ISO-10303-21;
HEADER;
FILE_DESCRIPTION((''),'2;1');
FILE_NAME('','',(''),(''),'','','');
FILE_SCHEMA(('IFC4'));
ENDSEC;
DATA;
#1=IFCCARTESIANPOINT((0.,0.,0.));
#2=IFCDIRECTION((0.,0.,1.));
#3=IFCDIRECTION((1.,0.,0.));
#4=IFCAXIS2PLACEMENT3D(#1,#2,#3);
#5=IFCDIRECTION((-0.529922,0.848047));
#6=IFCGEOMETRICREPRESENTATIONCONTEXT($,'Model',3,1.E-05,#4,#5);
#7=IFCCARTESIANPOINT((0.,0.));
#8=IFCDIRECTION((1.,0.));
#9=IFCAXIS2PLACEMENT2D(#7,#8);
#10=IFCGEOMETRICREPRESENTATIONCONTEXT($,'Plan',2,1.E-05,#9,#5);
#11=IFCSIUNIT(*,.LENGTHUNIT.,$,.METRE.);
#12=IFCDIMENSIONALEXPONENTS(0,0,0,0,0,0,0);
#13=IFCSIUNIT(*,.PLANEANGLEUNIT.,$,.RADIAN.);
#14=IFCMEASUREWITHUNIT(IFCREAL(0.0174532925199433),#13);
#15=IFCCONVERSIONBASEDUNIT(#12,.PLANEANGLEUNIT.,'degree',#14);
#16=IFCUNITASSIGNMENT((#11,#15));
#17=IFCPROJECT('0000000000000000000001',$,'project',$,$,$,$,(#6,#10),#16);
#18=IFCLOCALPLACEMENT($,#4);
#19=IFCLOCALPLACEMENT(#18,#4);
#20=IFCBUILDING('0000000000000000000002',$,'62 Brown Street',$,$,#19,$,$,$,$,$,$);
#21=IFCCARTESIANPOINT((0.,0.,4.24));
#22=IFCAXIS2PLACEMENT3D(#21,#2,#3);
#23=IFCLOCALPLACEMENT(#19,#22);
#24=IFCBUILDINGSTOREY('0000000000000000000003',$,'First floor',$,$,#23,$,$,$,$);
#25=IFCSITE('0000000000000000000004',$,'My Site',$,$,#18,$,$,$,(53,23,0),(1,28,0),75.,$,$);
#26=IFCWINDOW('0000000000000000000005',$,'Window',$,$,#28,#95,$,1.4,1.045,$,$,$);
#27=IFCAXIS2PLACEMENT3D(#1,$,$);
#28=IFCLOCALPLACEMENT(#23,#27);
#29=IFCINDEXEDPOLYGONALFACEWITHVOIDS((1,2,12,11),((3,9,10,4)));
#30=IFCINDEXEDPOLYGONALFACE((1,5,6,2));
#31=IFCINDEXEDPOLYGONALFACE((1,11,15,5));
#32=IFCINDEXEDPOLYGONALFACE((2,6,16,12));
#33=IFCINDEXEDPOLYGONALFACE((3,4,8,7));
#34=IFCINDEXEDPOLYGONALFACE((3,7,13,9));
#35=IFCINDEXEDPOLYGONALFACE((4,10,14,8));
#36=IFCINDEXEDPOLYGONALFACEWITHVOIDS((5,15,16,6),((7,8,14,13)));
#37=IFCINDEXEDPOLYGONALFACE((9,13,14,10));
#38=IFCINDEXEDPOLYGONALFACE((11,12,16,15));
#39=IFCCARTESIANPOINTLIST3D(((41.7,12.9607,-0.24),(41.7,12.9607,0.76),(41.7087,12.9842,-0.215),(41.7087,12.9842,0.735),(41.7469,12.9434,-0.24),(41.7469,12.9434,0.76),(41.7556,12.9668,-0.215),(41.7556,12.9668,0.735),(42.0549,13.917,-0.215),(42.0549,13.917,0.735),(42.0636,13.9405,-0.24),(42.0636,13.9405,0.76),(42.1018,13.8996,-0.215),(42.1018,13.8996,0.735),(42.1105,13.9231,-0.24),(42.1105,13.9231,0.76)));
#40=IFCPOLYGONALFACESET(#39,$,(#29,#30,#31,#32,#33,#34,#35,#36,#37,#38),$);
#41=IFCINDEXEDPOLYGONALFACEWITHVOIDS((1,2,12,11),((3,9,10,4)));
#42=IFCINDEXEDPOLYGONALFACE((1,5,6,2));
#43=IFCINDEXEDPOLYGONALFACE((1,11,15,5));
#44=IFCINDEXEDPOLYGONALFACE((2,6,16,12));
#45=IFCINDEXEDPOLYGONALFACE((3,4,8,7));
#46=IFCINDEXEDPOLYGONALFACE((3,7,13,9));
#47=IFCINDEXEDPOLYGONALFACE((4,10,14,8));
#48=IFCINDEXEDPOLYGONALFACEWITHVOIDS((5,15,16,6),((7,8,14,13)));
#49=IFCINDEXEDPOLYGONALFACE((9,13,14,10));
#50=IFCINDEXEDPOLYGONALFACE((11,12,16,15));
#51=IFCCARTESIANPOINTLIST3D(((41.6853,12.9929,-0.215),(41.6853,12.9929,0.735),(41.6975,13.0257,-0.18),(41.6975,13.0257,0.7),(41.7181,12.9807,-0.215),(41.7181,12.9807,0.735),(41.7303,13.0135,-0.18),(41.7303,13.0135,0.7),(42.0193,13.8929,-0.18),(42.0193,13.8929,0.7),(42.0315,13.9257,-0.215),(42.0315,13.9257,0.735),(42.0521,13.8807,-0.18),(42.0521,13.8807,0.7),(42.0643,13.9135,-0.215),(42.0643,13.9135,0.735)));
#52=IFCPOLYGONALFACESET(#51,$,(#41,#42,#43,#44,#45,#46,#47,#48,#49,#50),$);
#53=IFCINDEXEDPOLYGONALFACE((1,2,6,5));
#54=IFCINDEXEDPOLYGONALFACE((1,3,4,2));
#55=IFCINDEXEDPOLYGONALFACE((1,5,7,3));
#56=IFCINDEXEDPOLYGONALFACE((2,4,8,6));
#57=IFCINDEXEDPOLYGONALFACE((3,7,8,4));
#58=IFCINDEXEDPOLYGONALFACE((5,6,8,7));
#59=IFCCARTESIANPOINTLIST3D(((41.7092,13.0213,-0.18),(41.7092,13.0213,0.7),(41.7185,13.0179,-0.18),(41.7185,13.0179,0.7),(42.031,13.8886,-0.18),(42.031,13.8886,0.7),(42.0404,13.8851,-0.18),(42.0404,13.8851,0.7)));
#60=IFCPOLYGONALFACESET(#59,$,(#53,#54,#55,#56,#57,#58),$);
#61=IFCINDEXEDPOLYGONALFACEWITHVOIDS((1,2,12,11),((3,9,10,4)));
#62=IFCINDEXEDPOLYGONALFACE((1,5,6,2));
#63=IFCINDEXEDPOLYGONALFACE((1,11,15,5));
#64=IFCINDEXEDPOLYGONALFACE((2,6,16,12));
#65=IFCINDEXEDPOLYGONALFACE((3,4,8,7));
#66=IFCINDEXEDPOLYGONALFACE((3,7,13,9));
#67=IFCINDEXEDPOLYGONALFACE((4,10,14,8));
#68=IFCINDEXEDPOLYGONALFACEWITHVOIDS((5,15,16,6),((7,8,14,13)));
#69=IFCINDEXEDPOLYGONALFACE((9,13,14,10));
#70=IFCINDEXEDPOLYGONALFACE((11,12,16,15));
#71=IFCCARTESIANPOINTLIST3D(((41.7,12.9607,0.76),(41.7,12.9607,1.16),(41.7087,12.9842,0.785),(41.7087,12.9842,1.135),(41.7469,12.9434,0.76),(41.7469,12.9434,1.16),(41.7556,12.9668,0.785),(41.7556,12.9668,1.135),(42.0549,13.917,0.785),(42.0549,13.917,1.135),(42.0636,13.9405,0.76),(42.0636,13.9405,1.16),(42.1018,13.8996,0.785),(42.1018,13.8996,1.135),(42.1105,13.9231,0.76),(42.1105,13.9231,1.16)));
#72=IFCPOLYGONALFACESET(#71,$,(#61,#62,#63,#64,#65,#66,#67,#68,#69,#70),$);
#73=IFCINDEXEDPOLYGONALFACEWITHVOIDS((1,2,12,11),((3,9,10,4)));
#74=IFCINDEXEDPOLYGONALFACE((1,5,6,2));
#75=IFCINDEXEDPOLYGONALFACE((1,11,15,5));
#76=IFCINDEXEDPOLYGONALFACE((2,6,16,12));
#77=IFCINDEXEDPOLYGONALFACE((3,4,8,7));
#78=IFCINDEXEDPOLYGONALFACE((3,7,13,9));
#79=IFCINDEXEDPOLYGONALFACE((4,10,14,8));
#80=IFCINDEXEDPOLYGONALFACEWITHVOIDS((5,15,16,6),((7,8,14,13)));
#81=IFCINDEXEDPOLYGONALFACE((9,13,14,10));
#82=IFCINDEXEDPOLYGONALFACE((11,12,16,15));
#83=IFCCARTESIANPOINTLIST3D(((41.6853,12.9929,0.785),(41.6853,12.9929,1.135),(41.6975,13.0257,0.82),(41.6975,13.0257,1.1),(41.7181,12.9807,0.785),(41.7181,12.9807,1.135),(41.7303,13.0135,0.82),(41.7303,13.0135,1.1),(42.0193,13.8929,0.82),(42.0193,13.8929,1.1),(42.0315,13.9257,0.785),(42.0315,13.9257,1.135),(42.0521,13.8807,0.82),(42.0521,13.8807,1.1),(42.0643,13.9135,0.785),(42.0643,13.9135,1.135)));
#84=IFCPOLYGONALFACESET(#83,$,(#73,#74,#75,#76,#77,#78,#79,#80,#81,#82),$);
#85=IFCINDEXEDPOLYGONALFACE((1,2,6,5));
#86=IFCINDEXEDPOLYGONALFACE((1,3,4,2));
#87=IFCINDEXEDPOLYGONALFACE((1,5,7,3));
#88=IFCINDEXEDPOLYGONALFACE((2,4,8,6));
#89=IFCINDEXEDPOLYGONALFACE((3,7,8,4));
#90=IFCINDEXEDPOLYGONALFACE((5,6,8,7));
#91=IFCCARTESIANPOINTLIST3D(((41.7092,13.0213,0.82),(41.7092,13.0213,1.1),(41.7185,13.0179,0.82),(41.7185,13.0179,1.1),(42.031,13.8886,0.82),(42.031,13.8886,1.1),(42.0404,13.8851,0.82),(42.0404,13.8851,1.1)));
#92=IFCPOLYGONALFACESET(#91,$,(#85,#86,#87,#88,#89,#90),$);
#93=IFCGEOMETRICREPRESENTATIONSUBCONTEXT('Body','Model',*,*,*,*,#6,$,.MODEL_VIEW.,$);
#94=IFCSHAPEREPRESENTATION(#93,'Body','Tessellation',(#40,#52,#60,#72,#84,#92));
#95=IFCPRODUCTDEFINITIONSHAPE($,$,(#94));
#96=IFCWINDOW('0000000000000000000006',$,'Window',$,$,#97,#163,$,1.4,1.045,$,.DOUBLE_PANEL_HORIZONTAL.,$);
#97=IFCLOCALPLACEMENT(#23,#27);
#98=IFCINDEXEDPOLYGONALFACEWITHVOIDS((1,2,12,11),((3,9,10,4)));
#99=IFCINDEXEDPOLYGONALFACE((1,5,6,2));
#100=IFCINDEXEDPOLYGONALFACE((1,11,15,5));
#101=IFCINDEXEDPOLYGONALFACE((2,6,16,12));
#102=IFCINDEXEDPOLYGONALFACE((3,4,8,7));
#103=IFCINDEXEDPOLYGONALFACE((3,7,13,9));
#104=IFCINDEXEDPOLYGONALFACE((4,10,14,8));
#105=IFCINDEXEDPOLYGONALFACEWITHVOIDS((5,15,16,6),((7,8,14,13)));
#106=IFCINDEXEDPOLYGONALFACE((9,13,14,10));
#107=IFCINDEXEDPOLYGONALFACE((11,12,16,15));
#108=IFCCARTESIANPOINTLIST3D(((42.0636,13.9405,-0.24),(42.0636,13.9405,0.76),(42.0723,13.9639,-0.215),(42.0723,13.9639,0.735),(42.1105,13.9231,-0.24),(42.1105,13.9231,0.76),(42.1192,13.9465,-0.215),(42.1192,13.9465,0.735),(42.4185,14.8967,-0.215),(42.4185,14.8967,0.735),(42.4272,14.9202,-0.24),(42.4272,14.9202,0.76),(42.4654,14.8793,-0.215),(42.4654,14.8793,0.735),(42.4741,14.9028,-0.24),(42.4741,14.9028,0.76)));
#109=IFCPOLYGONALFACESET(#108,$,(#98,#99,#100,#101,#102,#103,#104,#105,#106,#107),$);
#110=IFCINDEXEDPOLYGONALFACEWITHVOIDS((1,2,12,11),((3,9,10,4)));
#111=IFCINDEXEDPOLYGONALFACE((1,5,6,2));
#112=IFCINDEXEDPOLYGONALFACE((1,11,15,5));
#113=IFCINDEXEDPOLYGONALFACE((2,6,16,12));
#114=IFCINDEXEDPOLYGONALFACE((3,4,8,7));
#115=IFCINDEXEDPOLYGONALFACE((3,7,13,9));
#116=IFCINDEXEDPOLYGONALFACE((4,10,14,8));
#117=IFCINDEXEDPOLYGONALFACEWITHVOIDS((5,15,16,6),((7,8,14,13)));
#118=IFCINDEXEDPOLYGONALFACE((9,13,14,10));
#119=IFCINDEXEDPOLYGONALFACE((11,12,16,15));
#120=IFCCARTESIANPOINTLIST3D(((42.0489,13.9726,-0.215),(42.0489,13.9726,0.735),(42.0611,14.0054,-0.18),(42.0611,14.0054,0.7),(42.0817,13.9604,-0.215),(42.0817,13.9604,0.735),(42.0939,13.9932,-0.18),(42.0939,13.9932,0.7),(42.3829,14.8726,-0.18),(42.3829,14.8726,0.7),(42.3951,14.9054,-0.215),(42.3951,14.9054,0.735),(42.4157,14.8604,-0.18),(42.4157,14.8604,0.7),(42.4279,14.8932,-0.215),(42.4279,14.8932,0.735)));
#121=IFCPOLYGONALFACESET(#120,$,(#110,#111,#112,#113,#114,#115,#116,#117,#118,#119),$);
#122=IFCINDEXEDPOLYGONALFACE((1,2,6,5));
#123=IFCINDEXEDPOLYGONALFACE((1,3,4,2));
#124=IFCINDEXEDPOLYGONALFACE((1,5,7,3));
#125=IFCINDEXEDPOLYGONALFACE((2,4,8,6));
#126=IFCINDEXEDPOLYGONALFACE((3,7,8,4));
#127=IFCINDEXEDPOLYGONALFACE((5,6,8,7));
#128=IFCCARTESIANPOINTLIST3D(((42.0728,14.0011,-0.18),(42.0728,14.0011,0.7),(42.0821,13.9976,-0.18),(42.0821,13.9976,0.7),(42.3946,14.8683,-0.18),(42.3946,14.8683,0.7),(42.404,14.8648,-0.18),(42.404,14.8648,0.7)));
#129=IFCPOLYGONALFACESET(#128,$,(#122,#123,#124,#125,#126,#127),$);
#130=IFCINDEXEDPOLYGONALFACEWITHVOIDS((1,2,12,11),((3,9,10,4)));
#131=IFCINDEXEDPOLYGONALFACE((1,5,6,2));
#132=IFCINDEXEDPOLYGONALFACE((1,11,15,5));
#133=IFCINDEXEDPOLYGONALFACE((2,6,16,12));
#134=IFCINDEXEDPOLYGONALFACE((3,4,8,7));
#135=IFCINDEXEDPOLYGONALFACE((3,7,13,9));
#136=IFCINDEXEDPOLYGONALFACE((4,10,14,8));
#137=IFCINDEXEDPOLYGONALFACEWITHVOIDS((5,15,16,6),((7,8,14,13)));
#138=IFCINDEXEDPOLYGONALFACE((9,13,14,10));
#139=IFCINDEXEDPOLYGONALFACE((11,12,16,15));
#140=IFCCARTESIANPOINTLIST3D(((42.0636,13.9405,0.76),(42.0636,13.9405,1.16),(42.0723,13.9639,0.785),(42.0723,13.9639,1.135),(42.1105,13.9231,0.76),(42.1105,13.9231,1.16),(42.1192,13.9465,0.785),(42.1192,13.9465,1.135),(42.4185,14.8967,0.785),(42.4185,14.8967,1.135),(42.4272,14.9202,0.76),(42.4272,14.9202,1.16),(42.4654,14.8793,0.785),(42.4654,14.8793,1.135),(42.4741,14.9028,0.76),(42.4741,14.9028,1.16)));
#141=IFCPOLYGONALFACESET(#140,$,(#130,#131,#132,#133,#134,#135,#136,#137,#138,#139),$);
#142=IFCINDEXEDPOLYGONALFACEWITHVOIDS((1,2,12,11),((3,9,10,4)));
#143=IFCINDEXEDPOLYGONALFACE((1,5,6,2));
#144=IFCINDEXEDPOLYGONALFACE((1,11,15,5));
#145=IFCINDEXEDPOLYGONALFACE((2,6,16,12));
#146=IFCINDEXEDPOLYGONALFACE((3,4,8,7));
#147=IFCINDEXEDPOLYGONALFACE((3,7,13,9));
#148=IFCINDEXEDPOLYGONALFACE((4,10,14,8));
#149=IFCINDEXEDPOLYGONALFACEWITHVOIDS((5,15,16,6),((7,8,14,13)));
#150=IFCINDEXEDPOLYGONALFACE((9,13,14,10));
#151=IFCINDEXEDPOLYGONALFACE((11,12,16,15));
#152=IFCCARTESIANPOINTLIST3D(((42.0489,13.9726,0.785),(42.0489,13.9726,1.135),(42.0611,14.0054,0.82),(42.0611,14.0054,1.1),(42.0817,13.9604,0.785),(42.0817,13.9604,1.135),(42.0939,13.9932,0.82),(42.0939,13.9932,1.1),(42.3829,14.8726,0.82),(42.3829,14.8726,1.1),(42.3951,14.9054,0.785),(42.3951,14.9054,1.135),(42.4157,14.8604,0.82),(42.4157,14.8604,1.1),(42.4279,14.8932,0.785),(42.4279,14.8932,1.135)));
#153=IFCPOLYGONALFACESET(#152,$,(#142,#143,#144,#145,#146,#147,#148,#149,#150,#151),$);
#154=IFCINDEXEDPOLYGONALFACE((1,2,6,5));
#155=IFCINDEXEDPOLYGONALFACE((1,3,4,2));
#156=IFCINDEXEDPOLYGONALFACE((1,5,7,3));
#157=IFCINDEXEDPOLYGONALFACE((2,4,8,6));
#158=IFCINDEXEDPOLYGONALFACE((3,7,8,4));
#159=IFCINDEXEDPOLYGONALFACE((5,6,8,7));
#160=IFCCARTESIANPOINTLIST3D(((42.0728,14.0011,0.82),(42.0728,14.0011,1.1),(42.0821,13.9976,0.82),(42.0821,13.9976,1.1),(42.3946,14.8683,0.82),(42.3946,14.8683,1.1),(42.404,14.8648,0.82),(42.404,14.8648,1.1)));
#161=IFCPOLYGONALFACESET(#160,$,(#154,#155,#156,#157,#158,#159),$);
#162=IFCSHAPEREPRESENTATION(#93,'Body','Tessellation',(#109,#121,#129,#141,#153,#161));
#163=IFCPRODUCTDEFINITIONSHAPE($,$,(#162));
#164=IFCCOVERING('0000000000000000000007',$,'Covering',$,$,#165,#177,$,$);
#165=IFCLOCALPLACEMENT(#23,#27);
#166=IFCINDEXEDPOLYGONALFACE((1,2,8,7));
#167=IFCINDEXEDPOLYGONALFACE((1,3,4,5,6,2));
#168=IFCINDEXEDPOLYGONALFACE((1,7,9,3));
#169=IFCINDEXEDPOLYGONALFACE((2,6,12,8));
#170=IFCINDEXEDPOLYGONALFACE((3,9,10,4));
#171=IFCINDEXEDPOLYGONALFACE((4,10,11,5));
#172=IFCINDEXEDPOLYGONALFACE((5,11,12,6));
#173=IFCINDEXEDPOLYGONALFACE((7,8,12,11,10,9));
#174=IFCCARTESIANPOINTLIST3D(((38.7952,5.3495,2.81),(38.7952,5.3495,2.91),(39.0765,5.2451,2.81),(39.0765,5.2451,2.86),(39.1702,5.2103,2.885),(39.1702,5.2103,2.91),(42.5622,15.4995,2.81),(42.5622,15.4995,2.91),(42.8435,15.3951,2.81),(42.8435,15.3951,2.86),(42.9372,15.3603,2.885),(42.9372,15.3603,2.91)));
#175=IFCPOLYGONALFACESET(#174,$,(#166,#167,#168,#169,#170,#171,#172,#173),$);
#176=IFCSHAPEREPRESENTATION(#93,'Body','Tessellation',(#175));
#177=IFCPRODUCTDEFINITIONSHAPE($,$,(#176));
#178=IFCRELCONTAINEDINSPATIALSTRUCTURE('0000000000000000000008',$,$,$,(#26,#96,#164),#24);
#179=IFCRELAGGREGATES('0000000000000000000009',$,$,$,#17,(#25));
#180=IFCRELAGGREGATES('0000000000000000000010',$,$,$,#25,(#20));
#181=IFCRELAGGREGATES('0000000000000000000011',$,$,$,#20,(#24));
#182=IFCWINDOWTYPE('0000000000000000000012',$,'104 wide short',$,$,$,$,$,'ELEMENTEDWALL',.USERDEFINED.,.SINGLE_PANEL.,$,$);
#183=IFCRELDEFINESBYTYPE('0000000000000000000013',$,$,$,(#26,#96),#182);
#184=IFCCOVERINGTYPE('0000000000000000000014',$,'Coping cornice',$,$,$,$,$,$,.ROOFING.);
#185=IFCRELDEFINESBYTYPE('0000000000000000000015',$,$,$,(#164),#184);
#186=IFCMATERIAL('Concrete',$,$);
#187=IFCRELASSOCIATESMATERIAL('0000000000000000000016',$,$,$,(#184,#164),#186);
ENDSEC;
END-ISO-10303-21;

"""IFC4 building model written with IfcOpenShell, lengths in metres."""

from ifc_helpers import new_model, entity, si_unit, converted_unit, direction, frame, origin_with_axes, origin_2d_with_axis, place, context, subcontext, project, spatial, line, indexed_curve, outline, extrude, shape, source, transform, mapped, material, material_profile, profile_set, profile_usage, type_object, type_shapes, element, save


model = new_model("IFC4")

# Units and contexts
model_context = context("Model", 3, precision=1e-05, world=origin_with_axes(), true_north=direction((-0.529922, 0.848047)))
plan_context = context("Plan", 2, precision=1e-05, world=origin_2d_with_axis(), true_north=direction((-0.529922, 0.848047)))
body_context_1 = subcontext(model_context, "Body", "Model", "MODEL_VIEW")
body_context_2 = subcontext(plan_context, "Body", "Plan", "PLAN_VIEW")
ifc_project = project(units=[si_unit("LENGTHUNIT", "METRE"), converted_unit("PLANEANGLEUNIT", "degree", entity("IfcReal", 0.0174532925199433), si_unit("PLANEANGLEUNIT", "RADIAN"), dimensions=[0, 0, 0, 0, 0, 0, 0])], contexts=[model_context, plan_context])

# Site, building, storey
site_placement = place(None, origin_with_axes())
site = spatial("IfcSite", under=ifc_project, at=site_placement, Name="My Site", RefLatitude=(53, 23, 0), RefLongitude=(1, 28, 0), RefElevation=75.0)
building_placement = place(site_placement, origin_with_axes())
building = spatial("IfcBuilding", under=site, at=building_placement, Name="62 Brown Street")
storey_placement = place(building_placement, frame((0.0, 0.0, 4.24), z_axis=(0.0, 0.0, 1.0), x_axis=(1.0, 0.0, 0.0)))
storey = spatial("IfcBuildingStorey", under=building, at=storey_placement, Name="First floor")

# Shared definitions
window_type = type_object("IfcWindowType", Name="104 wide short", ElementType="ELEMENTEDWALL", PartitioningType="SINGLE_PANEL", PredefinedType="USERDEFINED")
shared_shape_1 = source(origin_with_axes(), body_context_1, "Body", "SweptSolid", [
    extrude(outline(indexed_curve([(0.0, 0.0), (1.045, 0.0), (1.045, 1.0), (0.0, 1.0)], segments=[line(1, 2, 3, 4, 1)]), holes=[indexed_curve([(0.025, 0.025), (1.02, 0.025), (1.02, 0.975), (0.025, 0.975)], segments=[line(1, 2, 3, 4, 1)])]), frame((0.0, 0.15, 0.0), z_axis=(0.0, -1.0, 0.0), x_axis=(1.0, 0.0, 0.0)), (0.0, 0.0, -1.0), 0.05),
    extrude(outline(indexed_curve([(0.0, 0.0), (0.995, 0.0), (0.995, 0.95), (0.0, 0.95)], segments=[line(1, 2, 3, 4, 1)]), holes=[indexed_curve([(0.035, 0.035), (0.96, 0.035), (0.96, 0.915), (0.035, 0.915)], segments=[line(1, 2, 3, 4, 1)])]), frame((0.025, 0.19, 0.025), z_axis=(0.0, -1.0, 0.0), x_axis=(1.0, 0.0, 0.0)), (0.0, 0.0, -1.0), 0.035),
    extrude(outline(indexed_curve([(0.035, 0.035), (0.96, 0.035), (0.96, 0.915), (0.035, 0.915)], segments=[line(1, 2, 3, 4, 1)])), frame((0.025, 0.2025, 0.025), z_axis=(0.0, -1.0, 0.0), x_axis=(1.0, 0.0, 0.0)), (0.0, 0.0, -1.0), 0.01),
    extrude(outline(indexed_curve([(0.0, 0.0), (1.045, 0.0), (1.045, 0.4), (0.0, 0.4)], segments=[line(1, 2, 3, 4, 1)]), holes=[indexed_curve([(0.025, 0.025), (1.02, 0.025), (1.02, 0.375), (0.025, 0.375)], segments=[line(1, 2, 3, 4, 1)])]), frame((0.0, 0.15, 1.0), z_axis=(0.0, -1.0, 0.0), x_axis=(1.0, 0.0, 0.0)), (0.0, 0.0, -1.0), 0.05),
    extrude(outline(indexed_curve([(0.0, 0.0), (0.995, 0.0), (0.995, 0.35), (0.0, 0.35)], segments=[line(1, 2, 3, 4, 1)]), holes=[indexed_curve([(0.035, 0.035), (0.96, 0.035), (0.96, 0.315), (0.035, 0.315)], segments=[line(1, 2, 3, 4, 1)])]), frame((0.025, 0.19, 1.025), z_axis=(0.0, -1.0, 0.0), x_axis=(1.0, 0.0, 0.0)), (0.0, 0.0, -1.0), 0.035),
    extrude(outline(indexed_curve([(0.035, 0.035), (0.96, 0.035), (0.96, 0.315), (0.035, 0.315)], segments=[line(1, 2, 3, 4, 1)])), frame((0.025, 0.2025, 1.025), z_axis=(0.0, -1.0, 0.0), x_axis=(1.0, 0.0, 0.0)), (0.0, 0.0, -1.0), 0.01),
])
shared_shape_2 = source(origin_with_axes(), body_context_2, "Body", "Curve2D", [
    entity("IfcIndexedPolyCurve", entity("IfcCartesianPointList2D", [[0.025, 0.15], [1.02, 0.15]])),
    entity("IfcIndexedPolyCurve", entity("IfcCartesianPointList2D", [[0.0, 0.2], [0.025, 0.2], [0.025, 0.15], [0.0, 0.15]]), [entity("IfcLineIndex", [1, 2, 3, 4, 1])]),
    entity("IfcIndexedPolyCurve", entity("IfcCartesianPointList2D", [[1.045, 0.2], [1.02, 0.2], [1.02, 0.15], [1.045, 0.15]]), [entity("IfcLineIndex", [1, 2, 3, 4, 1])]),
    entity("IfcIndexedPolyCurve", entity("IfcCartesianPointList2D", [[0.025, 0.19], [0.06, 0.19], [0.06, 0.225], [0.025, 0.225]]), [entity("IfcLineIndex", [1, 2, 3, 4, 1])]),
    entity("IfcIndexedPolyCurve", entity("IfcCartesianPointList2D", [[1.02, 0.19], [0.985, 0.19], [0.985, 0.225], [1.02, 0.225]]), [entity("IfcLineIndex", [1, 2, 3, 4, 1])]),
    entity("IfcIndexedPolyCurve", entity("IfcCartesianPointList2D", [[0.06, 0.19], [0.985, 0.19]])),
    entity("IfcIndexedPolyCurve", entity("IfcCartesianPointList2D", [[0.06, 0.225], [0.985, 0.225]])),
    entity("IfcIndexedPolyCurve", entity("IfcCartesianPointList2D", [[0.06, 0.2075], [0.985, 0.2075]])),
])
type_shapes(window_type, [shared_shape_1, shared_shape_2])

# Windows
for number, where, z_axis, x_axis, name in (
    (1, (41.8875, 12.8912, -0.24), (0.0, 0.0, 1.0), (0.347944, 0.937515, 0.0), "Window"),
):
    element("IfcWindow", number, at=place(storey_placement, frame(where, z_axis=z_axis, x_axis=x_axis)), inside=storey, type_object=window_type, Name=name, OverallHeight=1.4, OverallWidth=1.045, shapes=[
        shape(body_context_1, "Body", "MappedRepresentation", [mapped(shared_shape_1, transform((0.0, 0.0, 0.0), x_axis=(1.0, 0.0, 0.0), y_axis=(0.0, 1.0, 0.0), z_axis=(0.0, 0.0, 1.0), scale=1.0))]),
        shape(body_context_2, "Body", "MappedRepresentation", [mapped(shared_shape_2, transform((0.0, 0.0, 0.0), x_axis=(1.0, 0.0, 0.0), y_axis=(0.0, 1.0, 0.0), z_axis=(0.0, 0.0, 1.0), scale=1.0))]),
    ])
window_1_placement = place(storey_placement, frame((42.2511, 13.8709, -0.24), z_axis=(0.0, 0.0, 1.0), x_axis=(0.347944, 0.937515, 0.0)))
element("IfcWindow", 2, at=window_1_placement, inside=storey, type_object=window_type, Name="Window", OverallHeight=1.4, OverallWidth=1.045, PartitioningType="DOUBLE_PANEL_HORIZONTAL", shapes=[
    shape(body_context_1, "Body", "MappedRepresentation", [mapped(shared_shape_1, transform((0.0, 0.0, 0.0), x_axis=(1.0, 0.0, 0.0), y_axis=(0.0, 1.0, 0.0), z_axis=(0.0, 0.0, 1.0), scale=1.0))]),
    shape(body_context_2, "Body", "MappedRepresentation", [mapped(shared_shape_2, transform((0.0, 0.0, 0.0), x_axis=(1.0, 0.0, 0.0), y_axis=(0.0, 1.0, 0.0), z_axis=(0.0, 0.0, 1.0), scale=1.0))]),
])

# Covering
ifc_material_1 = material(Name="Concrete")
ifc_material_profile = material_profile(ifc_material_1, outline(indexed_curve([(-0.2, 0.1), (0.2, 0.1), (0.2, 0.075), (0.1, 0.05), (0.1, 0.0), (-0.2, 0.0)], segments=[line(5, 4), line(4, 3), line(3, 2), line(2, 1), line(1, 6), line(6, 5)], self_intersect=False)))
ifc_profile_set = profile_set([ifc_material_profile], Name="cornice")
ifc_profile_usage = profile_usage(ifc_profile_set, cardinal=5)
covering_type = type_object("IfcCoveringType", Name="Coping cornice", PredefinedType="ROOFING", material=ifc_profile_set)
covering_placement = place(storey_placement, frame((42.7497, 15.4299, 2.81), z_axis=(-0.347944, -0.937515, 0.0), x_axis=(0.937515, -0.347944, 0.0)))
element("IfcCovering", 3, at=covering_placement, inside=storey, type_object=covering_type, material=ifc_profile_usage, Name="Covering", context=body_context_1, shape_type="SweptSolid", body=[
    extrude(outline(indexed_curve([(-0.2, 0.1), (0.2, 0.1), (0.2, 0.075), (0.1, 0.05), (0.1, 0.0), (-0.2, 0.0)], segments=[line(5, 4), line(4, 3), line(3, 2), line(2, 1), line(1, 6), line(6, 5)], self_intersect=False)), origin_with_axes(), (0.0, 0.0, 1.0), 10.8265),
])

save(model, "model.ifc")
